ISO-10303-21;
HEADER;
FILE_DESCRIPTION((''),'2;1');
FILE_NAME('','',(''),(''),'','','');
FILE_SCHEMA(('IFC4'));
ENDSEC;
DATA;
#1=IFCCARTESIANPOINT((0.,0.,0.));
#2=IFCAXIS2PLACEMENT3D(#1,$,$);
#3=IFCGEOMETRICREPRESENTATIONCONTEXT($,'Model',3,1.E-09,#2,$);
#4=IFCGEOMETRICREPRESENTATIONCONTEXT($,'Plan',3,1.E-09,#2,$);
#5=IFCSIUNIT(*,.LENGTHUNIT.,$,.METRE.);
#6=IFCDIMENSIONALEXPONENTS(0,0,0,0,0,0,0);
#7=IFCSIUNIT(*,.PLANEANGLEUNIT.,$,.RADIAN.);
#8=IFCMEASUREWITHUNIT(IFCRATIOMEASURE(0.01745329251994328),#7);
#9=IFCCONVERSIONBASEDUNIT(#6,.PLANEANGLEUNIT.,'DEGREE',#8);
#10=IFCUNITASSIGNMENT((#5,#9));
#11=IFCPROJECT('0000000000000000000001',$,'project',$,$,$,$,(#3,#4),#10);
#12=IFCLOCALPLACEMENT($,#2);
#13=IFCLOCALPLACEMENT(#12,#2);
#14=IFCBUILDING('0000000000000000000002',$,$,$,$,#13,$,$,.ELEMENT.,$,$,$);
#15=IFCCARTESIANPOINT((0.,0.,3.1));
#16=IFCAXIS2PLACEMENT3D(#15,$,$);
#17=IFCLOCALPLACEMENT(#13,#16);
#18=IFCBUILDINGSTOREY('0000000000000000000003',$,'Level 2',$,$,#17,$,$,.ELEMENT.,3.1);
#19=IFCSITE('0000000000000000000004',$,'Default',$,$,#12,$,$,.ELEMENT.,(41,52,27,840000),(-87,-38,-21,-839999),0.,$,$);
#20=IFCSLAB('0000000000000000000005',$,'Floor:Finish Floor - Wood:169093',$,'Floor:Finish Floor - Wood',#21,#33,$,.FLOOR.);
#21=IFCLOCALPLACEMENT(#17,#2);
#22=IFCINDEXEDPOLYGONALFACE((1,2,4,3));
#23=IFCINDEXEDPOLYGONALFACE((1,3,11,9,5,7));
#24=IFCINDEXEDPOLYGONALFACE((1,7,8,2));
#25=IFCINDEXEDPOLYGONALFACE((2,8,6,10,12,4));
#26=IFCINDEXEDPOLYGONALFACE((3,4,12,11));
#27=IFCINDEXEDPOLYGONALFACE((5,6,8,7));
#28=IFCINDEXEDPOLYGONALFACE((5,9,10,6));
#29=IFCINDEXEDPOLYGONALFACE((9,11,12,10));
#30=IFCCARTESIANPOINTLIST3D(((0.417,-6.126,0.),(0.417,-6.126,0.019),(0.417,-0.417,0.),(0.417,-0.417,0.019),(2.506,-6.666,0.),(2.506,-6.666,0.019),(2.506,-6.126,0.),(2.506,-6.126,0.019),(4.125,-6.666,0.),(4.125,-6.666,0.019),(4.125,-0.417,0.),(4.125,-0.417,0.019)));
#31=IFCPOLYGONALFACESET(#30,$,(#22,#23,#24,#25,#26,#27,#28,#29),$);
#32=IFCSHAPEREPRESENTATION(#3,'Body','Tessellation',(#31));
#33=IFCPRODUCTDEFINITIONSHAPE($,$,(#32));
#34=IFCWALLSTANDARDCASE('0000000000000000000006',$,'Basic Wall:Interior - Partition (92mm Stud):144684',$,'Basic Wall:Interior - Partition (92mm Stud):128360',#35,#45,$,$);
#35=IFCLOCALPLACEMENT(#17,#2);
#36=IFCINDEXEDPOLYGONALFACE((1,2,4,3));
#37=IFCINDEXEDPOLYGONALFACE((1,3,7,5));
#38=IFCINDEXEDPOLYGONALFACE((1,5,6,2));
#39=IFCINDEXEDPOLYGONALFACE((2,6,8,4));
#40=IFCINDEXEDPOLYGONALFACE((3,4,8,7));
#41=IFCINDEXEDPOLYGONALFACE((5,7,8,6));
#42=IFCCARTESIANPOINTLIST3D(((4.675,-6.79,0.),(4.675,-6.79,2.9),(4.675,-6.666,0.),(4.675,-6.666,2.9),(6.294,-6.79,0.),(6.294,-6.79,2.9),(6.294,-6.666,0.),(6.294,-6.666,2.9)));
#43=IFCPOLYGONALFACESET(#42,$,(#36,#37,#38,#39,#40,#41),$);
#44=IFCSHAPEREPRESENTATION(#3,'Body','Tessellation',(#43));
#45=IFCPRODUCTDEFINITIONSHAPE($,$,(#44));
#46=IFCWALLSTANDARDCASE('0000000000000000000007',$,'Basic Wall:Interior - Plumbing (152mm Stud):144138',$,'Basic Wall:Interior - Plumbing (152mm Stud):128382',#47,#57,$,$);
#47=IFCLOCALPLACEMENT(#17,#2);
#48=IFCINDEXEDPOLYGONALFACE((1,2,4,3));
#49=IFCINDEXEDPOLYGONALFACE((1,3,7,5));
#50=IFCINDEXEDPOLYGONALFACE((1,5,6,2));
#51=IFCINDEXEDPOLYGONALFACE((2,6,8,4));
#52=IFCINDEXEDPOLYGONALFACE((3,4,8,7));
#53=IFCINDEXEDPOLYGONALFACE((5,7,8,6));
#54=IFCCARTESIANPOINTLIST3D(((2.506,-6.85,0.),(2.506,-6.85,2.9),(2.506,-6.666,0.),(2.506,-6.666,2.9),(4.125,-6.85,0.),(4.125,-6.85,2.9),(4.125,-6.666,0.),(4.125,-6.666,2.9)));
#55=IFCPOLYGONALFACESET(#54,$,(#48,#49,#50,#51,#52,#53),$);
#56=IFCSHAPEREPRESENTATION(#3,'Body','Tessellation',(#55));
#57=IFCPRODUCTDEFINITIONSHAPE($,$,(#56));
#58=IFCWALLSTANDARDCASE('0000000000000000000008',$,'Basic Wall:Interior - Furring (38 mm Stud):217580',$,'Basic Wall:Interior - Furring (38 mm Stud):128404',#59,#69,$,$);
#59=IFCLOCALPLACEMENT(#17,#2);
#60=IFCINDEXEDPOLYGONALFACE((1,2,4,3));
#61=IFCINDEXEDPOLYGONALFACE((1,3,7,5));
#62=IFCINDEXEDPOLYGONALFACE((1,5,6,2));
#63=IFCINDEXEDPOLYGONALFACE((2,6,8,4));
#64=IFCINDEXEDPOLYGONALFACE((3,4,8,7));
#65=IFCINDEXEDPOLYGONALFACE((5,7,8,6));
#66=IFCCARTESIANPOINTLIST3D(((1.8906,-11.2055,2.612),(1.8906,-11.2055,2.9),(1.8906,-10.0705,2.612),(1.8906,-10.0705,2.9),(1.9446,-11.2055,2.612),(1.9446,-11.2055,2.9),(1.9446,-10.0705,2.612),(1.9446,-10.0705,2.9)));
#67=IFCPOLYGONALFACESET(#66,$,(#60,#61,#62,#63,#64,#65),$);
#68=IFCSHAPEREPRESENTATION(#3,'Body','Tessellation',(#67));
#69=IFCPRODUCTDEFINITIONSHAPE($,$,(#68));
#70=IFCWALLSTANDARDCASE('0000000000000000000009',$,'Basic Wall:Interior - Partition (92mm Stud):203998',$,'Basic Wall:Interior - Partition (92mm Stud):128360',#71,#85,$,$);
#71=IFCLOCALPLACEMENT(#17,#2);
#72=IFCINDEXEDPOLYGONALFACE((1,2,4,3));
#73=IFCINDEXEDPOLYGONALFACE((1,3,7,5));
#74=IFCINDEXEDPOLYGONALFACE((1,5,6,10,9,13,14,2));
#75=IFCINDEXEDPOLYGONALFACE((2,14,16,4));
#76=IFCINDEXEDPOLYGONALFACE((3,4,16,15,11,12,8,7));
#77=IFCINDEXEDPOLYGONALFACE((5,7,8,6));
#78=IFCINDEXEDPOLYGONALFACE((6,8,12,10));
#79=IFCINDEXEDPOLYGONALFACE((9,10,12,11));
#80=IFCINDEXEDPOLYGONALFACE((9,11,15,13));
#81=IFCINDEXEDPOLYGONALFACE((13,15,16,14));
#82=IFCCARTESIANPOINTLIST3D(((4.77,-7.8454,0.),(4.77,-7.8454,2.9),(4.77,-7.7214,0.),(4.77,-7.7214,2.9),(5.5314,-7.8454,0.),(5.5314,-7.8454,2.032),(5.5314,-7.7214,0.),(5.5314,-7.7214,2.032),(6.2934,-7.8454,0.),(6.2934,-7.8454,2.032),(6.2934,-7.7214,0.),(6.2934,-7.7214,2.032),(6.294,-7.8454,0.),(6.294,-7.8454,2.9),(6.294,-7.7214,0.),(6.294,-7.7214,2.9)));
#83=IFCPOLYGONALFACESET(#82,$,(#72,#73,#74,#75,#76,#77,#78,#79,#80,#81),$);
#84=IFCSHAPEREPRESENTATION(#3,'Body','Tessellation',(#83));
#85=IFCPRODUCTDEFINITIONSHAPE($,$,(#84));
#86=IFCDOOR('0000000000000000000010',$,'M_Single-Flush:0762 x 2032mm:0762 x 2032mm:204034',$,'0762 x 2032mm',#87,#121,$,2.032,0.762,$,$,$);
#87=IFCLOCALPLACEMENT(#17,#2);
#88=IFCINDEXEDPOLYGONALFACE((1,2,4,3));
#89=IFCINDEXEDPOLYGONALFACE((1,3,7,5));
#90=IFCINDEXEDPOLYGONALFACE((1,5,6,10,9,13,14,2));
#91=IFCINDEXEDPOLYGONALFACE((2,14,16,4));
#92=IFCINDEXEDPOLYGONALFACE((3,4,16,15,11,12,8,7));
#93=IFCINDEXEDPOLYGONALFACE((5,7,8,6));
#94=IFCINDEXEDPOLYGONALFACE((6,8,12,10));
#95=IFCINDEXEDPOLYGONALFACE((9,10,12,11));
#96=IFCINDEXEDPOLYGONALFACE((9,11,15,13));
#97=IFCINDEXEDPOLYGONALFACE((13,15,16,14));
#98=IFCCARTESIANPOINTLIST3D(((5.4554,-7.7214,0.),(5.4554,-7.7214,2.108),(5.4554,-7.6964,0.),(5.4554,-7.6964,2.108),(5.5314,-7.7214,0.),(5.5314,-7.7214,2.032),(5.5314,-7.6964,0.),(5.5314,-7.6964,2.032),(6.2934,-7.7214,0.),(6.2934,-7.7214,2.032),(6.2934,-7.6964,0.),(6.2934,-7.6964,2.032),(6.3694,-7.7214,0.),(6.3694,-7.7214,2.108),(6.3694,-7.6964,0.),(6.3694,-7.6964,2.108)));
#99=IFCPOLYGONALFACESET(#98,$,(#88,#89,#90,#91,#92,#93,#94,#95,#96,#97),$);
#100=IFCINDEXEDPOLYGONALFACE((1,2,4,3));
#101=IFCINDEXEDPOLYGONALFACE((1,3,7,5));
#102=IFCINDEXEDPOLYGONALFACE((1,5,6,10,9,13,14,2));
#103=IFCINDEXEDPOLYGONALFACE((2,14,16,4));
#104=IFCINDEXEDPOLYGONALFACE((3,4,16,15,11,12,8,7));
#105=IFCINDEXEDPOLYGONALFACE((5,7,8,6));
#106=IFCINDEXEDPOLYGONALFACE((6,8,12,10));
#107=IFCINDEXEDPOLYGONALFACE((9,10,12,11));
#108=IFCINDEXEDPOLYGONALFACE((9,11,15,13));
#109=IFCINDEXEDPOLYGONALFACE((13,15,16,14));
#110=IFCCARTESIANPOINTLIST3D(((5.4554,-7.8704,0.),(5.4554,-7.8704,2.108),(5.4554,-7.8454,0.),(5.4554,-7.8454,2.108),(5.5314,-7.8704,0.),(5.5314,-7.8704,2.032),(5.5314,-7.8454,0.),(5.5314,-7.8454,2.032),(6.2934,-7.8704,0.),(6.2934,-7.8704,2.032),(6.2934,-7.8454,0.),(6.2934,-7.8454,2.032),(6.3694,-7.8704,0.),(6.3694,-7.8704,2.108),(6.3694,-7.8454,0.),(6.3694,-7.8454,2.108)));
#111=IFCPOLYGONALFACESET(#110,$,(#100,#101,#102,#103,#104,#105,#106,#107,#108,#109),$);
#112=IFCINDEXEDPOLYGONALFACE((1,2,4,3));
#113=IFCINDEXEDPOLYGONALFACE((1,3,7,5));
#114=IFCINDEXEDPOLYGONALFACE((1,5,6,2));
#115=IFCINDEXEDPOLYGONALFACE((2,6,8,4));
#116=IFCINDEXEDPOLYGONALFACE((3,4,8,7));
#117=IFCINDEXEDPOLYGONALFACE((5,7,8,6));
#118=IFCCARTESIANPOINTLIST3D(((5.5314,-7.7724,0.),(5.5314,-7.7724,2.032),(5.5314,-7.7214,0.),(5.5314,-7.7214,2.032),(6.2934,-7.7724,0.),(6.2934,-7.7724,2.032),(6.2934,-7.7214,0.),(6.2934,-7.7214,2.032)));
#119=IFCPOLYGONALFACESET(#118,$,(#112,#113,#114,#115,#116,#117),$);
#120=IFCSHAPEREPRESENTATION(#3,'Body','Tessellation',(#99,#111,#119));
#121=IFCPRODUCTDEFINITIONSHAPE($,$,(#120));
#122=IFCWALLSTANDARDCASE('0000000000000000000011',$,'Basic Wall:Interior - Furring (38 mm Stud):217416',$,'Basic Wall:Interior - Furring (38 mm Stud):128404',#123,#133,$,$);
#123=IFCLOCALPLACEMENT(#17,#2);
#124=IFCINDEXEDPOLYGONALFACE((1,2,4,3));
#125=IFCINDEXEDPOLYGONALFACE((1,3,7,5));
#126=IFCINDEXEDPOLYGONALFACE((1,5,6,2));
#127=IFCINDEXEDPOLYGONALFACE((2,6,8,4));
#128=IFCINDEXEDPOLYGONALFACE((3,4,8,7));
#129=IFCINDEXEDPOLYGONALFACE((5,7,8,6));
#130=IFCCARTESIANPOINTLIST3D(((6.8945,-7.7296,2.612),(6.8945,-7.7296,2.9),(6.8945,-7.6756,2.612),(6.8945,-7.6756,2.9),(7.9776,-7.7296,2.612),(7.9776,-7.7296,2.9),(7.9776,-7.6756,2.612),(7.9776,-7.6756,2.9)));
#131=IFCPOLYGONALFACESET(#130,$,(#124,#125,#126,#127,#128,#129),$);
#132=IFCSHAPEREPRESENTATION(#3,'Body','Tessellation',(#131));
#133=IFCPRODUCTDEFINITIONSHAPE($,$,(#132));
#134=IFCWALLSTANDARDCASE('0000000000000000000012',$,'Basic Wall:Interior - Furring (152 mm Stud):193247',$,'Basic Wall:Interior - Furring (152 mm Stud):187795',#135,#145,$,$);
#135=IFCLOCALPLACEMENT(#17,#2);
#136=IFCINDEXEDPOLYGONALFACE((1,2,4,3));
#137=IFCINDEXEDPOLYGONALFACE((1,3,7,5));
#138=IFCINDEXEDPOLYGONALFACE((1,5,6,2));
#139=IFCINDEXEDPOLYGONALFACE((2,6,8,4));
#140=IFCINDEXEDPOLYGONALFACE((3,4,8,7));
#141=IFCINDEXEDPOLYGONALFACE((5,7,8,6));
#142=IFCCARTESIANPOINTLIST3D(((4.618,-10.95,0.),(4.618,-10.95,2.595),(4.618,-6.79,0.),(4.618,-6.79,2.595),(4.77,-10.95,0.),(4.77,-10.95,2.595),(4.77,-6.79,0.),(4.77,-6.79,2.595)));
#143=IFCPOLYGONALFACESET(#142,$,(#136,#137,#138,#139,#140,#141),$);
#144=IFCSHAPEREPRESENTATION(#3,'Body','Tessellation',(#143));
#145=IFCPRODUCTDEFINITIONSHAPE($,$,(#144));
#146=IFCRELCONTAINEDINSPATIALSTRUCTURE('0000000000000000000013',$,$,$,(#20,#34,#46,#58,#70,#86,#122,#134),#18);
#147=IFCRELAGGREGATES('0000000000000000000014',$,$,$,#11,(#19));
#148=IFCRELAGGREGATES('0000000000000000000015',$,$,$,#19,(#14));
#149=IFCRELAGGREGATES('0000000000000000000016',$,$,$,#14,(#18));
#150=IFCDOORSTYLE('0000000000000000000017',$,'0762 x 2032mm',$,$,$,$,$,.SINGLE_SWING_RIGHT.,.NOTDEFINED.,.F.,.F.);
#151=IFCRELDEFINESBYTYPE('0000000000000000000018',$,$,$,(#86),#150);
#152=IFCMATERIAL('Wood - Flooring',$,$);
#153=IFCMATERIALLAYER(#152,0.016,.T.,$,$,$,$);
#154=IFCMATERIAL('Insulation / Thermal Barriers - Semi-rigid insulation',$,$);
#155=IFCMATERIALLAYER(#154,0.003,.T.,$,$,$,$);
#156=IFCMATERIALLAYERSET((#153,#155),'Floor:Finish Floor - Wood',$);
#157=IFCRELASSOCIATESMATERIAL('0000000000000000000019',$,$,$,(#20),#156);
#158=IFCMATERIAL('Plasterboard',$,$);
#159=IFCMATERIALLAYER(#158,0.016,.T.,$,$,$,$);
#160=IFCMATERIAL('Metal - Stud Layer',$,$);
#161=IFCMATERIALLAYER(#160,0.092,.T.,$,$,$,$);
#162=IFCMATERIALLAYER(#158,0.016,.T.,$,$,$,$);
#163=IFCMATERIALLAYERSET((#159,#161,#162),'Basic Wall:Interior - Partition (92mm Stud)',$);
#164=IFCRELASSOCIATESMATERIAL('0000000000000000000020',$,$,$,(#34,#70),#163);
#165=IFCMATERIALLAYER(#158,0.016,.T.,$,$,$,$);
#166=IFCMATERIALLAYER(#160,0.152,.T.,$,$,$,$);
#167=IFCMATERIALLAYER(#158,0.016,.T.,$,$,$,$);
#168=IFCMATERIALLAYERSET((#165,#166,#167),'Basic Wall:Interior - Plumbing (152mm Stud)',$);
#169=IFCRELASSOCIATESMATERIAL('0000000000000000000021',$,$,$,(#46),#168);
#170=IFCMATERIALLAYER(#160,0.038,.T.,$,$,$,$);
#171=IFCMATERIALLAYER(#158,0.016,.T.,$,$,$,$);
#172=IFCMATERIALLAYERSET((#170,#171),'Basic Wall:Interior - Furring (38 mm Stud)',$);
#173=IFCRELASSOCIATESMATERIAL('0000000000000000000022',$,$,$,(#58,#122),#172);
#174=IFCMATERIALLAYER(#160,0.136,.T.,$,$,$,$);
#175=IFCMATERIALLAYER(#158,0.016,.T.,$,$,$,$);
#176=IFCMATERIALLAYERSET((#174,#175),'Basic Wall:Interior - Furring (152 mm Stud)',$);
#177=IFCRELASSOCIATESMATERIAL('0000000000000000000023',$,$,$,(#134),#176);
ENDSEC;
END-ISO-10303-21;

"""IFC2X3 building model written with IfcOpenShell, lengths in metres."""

from ifc_helpers import new_model, entity, si_unit, converted_unit, frame, frame_2d, origin, origin_2d_with_axis, place, context, project, spatial, polyline, rectangle, outline, extrude, source, transform, mapped, material, layer, layer_set, layer_usage, type_object, type_shapes, element, fill, save


model = new_model("IFC2X3")

# Units and contexts
model_context = context("Model", 3, precision=1e-09, world=origin())
plan_context = context("Plan", 3, precision=1e-09, world=origin())
ifc_project = project(units=[si_unit("LENGTHUNIT", "METRE"), converted_unit("PLANEANGLEUNIT", "DEGREE", entity("IfcRatioMeasure", 0.01745329251994328), si_unit("PLANEANGLEUNIT", "RADIAN"), dimensions=[0, 0, 0, 0, 0, 0, 0])], contexts=[model_context, plan_context])

# Site, building, storey
site_placement = place(None, origin())
site = spatial("IfcSite", under=ifc_project, at=site_placement, Name="Default", CompositionType="ELEMENT", RefLatitude=(41, 52, 27, 840000), RefLongitude=(-87, -38, -21, -839999), RefElevation=0.0)
building_placement = place(site_placement, origin())
building = spatial("IfcBuilding", under=site, at=building_placement, CompositionType="ELEMENT")
storey_placement = place(building_placement, frame((0.0, 0.0, 3.1)))
storey = spatial("IfcBuildingStorey", under=building, at=storey_placement, Name="Level 2", CompositionType="ELEMENT", Elevation=3.1)

# Slab
ifc_material_1 = material(Name="Wood - Flooring")
ifc_layer_1 = layer(ifc_material_1, 0.016, ventilated=True)
ifc_material_2 = material(Name="Insulation / Thermal Barriers - Semi-rigid insulation")
ifc_layer_2 = layer(ifc_material_2, 0.003, ventilated=True)
ifc_layer_set_1 = layer_set([ifc_layer_1, ifc_layer_2], Name="Floor:Finish Floor - Wood")
ifc_layer_usage_1 = layer_usage(ifc_layer_set_1, "AXIS3", "POSITIVE", 0.0)
slab_placement = place(storey_placement, frame((0.417, -6.666, 0.0)))
element("IfcSlab", 1, at=slab_placement, inside=storey, material=ifc_layer_usage_1, Name="Floor:Finish Floor - Wood:169093", ObjectType="Floor:Finish Floor - Wood", PredefinedType="FLOOR", context=model_context, shape_type="SweptSolid", body=[
    extrude(outline(polyline([(1.854, 3.1245), (-1.854, 3.1245), (-1.854, -3.1245), (-0.235, -3.1245), (-0.235, -2.5845), (1.854, -2.5845), (1.854, 3.1245)])), frame((1.854, 3.1245, 0.019), z_axis=(0.0, 0.0, -1.0), x_axis=(-1.0, 0.0, 0.0)), (0.0, 0.0, 1.0), 0.019),
])

# Walls
ifc_material_3 = material(Name="Plasterboard")
ifc_layer_3 = layer(ifc_material_3, 0.016, ventilated=True)
ifc_material_4 = material(Name="Metal - Stud Layer")
ifc_layer_4 = layer(ifc_material_4, 0.092, ventilated=True)
ifc_layer_5 = layer(ifc_material_3, 0.016, ventilated=True)
ifc_layer_set_2 = layer_set([ifc_layer_3, ifc_layer_4, ifc_layer_5], Name="Basic Wall:Interior - Partition (92mm Stud)")
ifc_layer_usage_2 = layer_usage(ifc_layer_set_2, "AXIS2", "NEGATIVE", 0.062)
wall_1_placement = place(storey_placement, frame((4.675, -6.728, 0.0)))
element("IfcWallStandardCase", 2, at=wall_1_placement, inside=storey, material=ifc_layer_usage_2, Name="Basic Wall:Interior - Partition (92mm Stud):144684", ObjectType="Basic Wall:Interior - Partition (92mm Stud):128360", context=model_context, shape_type="SweptSolid", body=[
    extrude(rectangle(XDim=1.619, YDim=0.124, at=frame_2d((0.8095, 0.0), x_axis=(-1.0, 0.0))), origin(), (0.0, 0.0, 1.0), 2.9),
])
ifc_layer_6 = layer(ifc_material_3, 0.016, ventilated=True)
ifc_layer_7 = layer(ifc_material_4, 0.152, ventilated=True)
ifc_layer_8 = layer(ifc_material_3, 0.016, ventilated=True)
ifc_layer_set_3 = layer_set([ifc_layer_6, ifc_layer_7, ifc_layer_8], Name="Basic Wall:Interior - Plumbing (152mm Stud)")
ifc_layer_usage_3 = layer_usage(ifc_layer_set_3, "AXIS2", "NEGATIVE", 0.092)
wall_2_placement = place(storey_placement, frame((2.506, -6.758, 0.0)))
element("IfcWallStandardCase", 3, at=wall_2_placement, inside=storey, material=ifc_layer_usage_3, Name="Basic Wall:Interior - Plumbing (152mm Stud):144138", ObjectType="Basic Wall:Interior - Plumbing (152mm Stud):128382", context=model_context, shape_type="SweptSolid", body=[
    extrude(rectangle(XDim=1.619, YDim=0.184, at=frame_2d((0.8095, 0.0), x_axis=(-1.0, 0.0))), origin(), (0.0, 0.0, 1.0), 2.9),
])
ifc_layer_9 = layer(ifc_material_4, 0.038, ventilated=True)
ifc_layer_10 = layer(ifc_material_3, 0.016, ventilated=True)
ifc_layer_set_4 = layer_set([ifc_layer_9, ifc_layer_10], Name="Basic Wall:Interior - Furring (38 mm Stud)")
ifc_layer_usage_4 = layer_usage(ifc_layer_set_4, "AXIS2", "NEGATIVE", 0.027)
wall_3_placement = place(storey_placement, frame((1.9176, -10.0705, 2.612), z_axis=(0.0, 0.0, 1.0), x_axis=(0.0, -1.0, 0.0)))
element("IfcWallStandardCase", 4, at=wall_3_placement, inside=storey, material=ifc_layer_usage_4, Name="Basic Wall:Interior - Furring (38 mm Stud):217580", ObjectType="Basic Wall:Interior - Furring (38 mm Stud):128404", context=model_context, shape_type="SweptSolid", body=[
    extrude(rectangle(XDim=1.1351, YDim=0.054, at=frame_2d((0.5675, 0.0), x_axis=(-1.0, 0.0))), origin(), (0.0, 0.0, 1.0), 0.288),
])

# Wall, opening, door
ifc_layer_usage_5 = layer_usage(ifc_layer_set_2, "AXIS2", "POSITIVE", -0.062)
wall_4_placement = place(storey_placement, frame((4.77, -7.7834, 0.0)))
wall_4 = element("IfcWallStandardCase", 5, at=wall_4_placement, inside=storey, material=ifc_layer_usage_5, Name="Basic Wall:Interior - Partition (92mm Stud):203998", ObjectType="Basic Wall:Interior - Partition (92mm Stud):128360", context=model_context, shape_type="SweptSolid", body=[
    extrude(rectangle(XDim=1.524, YDim=0.124, at=frame_2d((0.762, 0.0), x_axis=(-1.0, 0.0))), origin(), (0.0, 0.0, 1.0), 2.9),
])
opening_1_placement = place(wall_4_placement, frame((0.7614, -0.062, 0.0)))
opening_1 = element("IfcOpeningElement", 6, at=opening_1_placement, cuts=wall_4, ObjectType="Opening", context=model_context, shape_type="SweptSolid", body=[
    extrude(rectangle(XDim=0.762, YDim=2.032, at=frame_2d((1.016, 0.381), x_axis=(0.0, 1.0))), frame((0.0, 0.0, 0.0), z_axis=(0.0, 1.0, 0.0), x_axis=(0.0, 0.0, 1.0)), (0.0, 0.0, 1.0), 0.124),
])
door_style = type_object("IfcDoorStyle", Name="0762 x 2032mm", ConstructionType="NOTDEFINED", OperationType="SINGLE_SWING_RIGHT", ParameterTakesPrecedence=False, Sizeable=False)
shared_shape = source(origin(), model_context, "Body", "SweptSolid", [
    extrude(outline(polyline([(-0.457, -1.073), (0.457, -1.073), (0.457, 1.035), (0.381, 1.035), (0.381, -0.997), (-0.381, -0.997), (-0.381, 1.035), (-0.457, 1.035), (-0.457, -1.073)])), frame((0.381, 0.124, 1.035), z_axis=(0.0, 1.0, 0.0), x_axis=(1.0, 0.0, 0.0)), (0.0, 0.0, 1.0), 0.025),
    extrude(outline(polyline([(-1.073, -0.457), (1.035, -0.457), (1.035, -0.381), (-0.997, -0.381), (-0.997, 0.381), (1.035, 0.381), (1.035, 0.457), (-1.073, 0.457), (-1.073, -0.457)])), frame((0.381, -0.025, 1.035), z_axis=(0.0, 1.0, 0.0), x_axis=(0.0, 0.0, -1.0)), (0.0, 0.0, 1.0), 0.025),
    extrude(rectangle(XDim=0.051, YDim=0.762, at=origin_2d_with_axis()), frame((0.381, 0.0985, 0.0), z_axis=(0.0, 0.0, 1.0), x_axis=(0.0, 1.0, 0.0)), (0.0, 0.0, 1.0), 2.032),
])
type_shapes(door_style, [shared_shape])
door_1_placement = place(opening_1_placement, origin())
door_1 = element("IfcDoor", 7, at=door_1_placement, inside=storey, type_object=door_style, Name="M_Single-Flush:0762 x 2032mm:0762 x 2032mm:204034", ObjectType="0762 x 2032mm", OverallHeight=2.032, OverallWidth=0.762, context=model_context, shape_type="MappedRepresentation", body=[
    mapped(shared_shape, transform((0.0, 0.0, 0.0), scale=1.0)),
])
fill(opening_1, door_1)

# Walls
wall_5_placement = place(storey_placement, frame((7.9776, -7.7026, 2.612), z_axis=(0.0, 0.0, 1.0), x_axis=(-1.0, 0.0, 0.0)))
element("IfcWallStandardCase", 8, at=wall_5_placement, inside=storey, material=ifc_layer_usage_4, Name="Basic Wall:Interior - Furring (38 mm Stud):217416", ObjectType="Basic Wall:Interior - Furring (38 mm Stud):128404", context=model_context, shape_type="SweptSolid", body=[
    extrude(rectangle(XDim=1.0831, YDim=0.054, at=frame_2d((0.5416, 0.0), x_axis=(-1.0, 0.0))), origin(), (0.0, 0.0, 1.0), 0.288),
])
ifc_layer_11 = layer(ifc_material_4, 0.136, ventilated=True)
ifc_layer_12 = layer(ifc_material_3, 0.016, ventilated=True)
ifc_layer_set_5 = layer_set([ifc_layer_11, ifc_layer_12], Name="Basic Wall:Interior - Furring (152 mm Stud)")
ifc_layer_usage_6 = layer_usage(ifc_layer_set_5, "AXIS2", "POSITIVE", -0.076)
wall_6_placement = place(storey_placement, frame((4.694, -6.79, 0.0), z_axis=(0.0, 0.0, 1.0), x_axis=(0.0, -1.0, 0.0)))
element("IfcWallStandardCase", 9, at=wall_6_placement, inside=storey, material=ifc_layer_usage_6, Name="Basic Wall:Interior - Furring (152 mm Stud):193247", ObjectType="Basic Wall:Interior - Furring (152 mm Stud):187795", context=model_context, shape_type="SweptSolid", body=[
    extrude(rectangle(XDim=4.16, YDim=0.152, at=frame_2d((2.08, 0.0), x_axis=(-1.0, 0.0))), origin(), (0.0, 0.0, 1.0), 2.595),
])

save(model, "model.ifc")
